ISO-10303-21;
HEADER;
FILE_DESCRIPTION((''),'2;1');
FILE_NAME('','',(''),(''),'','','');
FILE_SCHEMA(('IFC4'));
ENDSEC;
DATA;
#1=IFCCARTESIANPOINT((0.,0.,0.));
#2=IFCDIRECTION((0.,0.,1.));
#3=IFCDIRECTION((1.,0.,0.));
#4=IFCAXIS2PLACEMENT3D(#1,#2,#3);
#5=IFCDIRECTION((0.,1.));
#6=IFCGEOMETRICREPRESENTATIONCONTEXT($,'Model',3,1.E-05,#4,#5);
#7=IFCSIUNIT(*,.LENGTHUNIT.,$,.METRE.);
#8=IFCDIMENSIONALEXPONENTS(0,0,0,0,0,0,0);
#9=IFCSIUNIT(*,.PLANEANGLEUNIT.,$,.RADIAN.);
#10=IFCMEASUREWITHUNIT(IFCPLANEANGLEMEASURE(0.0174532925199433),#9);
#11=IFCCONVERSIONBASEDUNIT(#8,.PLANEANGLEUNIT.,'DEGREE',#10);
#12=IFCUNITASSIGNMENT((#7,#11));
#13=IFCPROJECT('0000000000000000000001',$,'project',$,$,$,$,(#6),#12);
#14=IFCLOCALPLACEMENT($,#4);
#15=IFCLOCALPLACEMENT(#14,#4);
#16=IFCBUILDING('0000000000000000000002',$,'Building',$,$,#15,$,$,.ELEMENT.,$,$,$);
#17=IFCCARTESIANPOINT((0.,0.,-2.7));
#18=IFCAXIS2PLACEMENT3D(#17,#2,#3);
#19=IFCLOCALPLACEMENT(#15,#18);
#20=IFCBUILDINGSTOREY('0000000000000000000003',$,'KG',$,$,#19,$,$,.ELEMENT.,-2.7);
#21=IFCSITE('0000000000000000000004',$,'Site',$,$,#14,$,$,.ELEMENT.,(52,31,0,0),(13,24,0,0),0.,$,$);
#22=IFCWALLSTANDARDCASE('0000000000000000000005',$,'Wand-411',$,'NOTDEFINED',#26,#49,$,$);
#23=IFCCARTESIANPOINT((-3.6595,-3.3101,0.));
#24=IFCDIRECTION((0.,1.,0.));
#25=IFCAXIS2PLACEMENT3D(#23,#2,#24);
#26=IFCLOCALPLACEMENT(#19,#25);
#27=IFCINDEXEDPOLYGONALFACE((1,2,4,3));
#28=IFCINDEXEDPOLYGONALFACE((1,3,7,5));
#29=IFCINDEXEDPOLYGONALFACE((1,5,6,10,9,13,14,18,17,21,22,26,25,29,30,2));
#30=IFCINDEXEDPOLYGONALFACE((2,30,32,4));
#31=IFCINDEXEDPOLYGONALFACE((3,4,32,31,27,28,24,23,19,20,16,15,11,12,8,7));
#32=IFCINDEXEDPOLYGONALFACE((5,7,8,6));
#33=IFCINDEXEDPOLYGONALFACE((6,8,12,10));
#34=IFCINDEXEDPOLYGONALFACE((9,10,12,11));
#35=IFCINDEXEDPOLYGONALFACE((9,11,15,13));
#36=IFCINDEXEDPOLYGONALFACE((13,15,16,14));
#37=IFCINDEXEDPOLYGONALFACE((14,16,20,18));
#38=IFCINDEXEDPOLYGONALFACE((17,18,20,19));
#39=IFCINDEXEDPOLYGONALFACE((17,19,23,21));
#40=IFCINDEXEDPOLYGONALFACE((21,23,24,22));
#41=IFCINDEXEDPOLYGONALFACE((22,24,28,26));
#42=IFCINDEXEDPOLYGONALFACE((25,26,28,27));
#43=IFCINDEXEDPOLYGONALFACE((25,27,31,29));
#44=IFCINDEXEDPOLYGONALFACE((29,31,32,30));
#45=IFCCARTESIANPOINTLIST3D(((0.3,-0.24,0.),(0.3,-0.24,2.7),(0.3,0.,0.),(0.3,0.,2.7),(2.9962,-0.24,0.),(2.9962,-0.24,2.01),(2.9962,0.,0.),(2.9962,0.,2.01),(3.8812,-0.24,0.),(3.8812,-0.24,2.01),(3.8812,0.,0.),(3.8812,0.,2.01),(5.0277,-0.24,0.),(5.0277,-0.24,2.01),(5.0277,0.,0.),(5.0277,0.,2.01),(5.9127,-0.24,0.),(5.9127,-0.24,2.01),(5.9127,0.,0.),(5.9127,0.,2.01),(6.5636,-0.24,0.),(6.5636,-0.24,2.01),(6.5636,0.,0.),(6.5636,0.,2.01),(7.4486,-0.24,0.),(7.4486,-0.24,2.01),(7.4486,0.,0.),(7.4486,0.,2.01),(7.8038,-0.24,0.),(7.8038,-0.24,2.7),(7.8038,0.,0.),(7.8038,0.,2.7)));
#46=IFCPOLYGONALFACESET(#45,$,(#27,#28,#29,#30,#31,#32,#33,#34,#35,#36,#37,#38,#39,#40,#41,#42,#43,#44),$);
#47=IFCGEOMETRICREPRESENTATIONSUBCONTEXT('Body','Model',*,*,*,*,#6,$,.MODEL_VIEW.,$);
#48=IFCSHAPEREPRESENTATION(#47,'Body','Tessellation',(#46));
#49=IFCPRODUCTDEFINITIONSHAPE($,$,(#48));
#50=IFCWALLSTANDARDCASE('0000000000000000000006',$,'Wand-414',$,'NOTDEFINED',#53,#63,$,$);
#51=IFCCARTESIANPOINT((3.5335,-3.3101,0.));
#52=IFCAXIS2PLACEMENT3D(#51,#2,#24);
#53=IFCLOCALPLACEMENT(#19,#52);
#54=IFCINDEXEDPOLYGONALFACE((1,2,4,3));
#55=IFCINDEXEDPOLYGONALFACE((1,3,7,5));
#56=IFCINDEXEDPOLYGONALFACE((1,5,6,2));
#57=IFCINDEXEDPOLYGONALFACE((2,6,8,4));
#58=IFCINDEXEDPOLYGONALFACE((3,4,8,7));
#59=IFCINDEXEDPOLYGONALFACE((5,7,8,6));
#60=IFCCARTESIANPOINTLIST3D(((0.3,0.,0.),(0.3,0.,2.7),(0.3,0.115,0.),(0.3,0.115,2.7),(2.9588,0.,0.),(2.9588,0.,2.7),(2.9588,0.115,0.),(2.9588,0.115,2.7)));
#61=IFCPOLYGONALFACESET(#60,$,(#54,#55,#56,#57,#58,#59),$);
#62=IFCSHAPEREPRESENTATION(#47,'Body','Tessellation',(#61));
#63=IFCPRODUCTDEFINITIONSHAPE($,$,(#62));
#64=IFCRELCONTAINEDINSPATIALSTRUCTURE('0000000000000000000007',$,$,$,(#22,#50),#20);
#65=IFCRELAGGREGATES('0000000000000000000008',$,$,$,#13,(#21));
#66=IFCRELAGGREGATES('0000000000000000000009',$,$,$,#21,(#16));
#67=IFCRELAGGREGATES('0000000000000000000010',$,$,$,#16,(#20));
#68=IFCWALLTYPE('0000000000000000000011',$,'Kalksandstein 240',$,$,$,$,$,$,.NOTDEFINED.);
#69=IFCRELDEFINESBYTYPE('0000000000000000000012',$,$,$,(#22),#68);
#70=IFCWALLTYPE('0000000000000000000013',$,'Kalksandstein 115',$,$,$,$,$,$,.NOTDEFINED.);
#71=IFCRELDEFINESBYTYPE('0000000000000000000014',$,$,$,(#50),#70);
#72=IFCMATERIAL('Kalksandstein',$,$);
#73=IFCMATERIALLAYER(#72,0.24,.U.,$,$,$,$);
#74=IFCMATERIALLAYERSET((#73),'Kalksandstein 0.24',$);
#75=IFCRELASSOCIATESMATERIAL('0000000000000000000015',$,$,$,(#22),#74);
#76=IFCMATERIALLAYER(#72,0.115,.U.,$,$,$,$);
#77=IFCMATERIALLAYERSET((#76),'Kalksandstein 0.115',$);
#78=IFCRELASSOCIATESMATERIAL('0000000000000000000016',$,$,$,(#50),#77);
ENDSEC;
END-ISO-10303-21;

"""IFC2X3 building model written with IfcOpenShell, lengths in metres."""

from ifc_helpers import new_model, entity, si_unit, converted_unit, direction, frame, origin_with_axes, origin_2d_with_axis, place, context, subcontext, project, spatial, polyline, rectangle, outline, extrude, material, layer, layer_set, layer_usage, type_object, element, save


model = new_model("IFC2X3")

# Units and contexts
model_context = context("Model", 3, precision=1e-05, world=origin_with_axes(), true_north=direction((0.0, 1.0)))
body_context = subcontext(model_context, "Body", "Model", "MODEL_VIEW")
ifc_project = project(units=[si_unit("LENGTHUNIT", "METRE"), converted_unit("PLANEANGLEUNIT", "DEGREE", entity("IfcPlaneAngleMeasure", 0.0174532925199433), si_unit("PLANEANGLEUNIT", "RADIAN"), dimensions=[0, 0, 0, 0, 0, 0, 0])], contexts=[model_context])

# Site, building, storey
site_placement = place(None, origin_with_axes())
site = spatial("IfcSite", under=ifc_project, at=site_placement, Name="Site", CompositionType="ELEMENT", RefLatitude=(52, 31, 0, 0), RefLongitude=(13, 24, 0, 0), RefElevation=0.0)
building_placement = place(site_placement, origin_with_axes())
building = spatial("IfcBuilding", under=site, at=building_placement, Name="Building", CompositionType="ELEMENT")
storey_placement = place(building_placement, frame((0.0, 0.0, -2.7), z_axis=(0.0, 0.0, 1.0), x_axis=(1.0, 0.0, 0.0)))
storey = spatial("IfcBuildingStorey", under=building, at=storey_placement, Name="KG", CompositionType="ELEMENT", Elevation=-2.7)

# Shared definitions
ifc_material = material(Name="Kalksandstein")

# Wall, openings
ifc_layer_1 = layer(ifc_material, 0.24, ventilated="UNKNOWN")
ifc_layer_set_1 = layer_set([ifc_layer_1], Name="Kalksandstein 0.24")
ifc_layer_usage_1 = layer_usage(ifc_layer_set_1, "AXIS2", "NEGATIVE", 0.0)
wall_type_1 = type_object("IfcWallType", Name="Kalksandstein 240", PredefinedType="NOTDEFINED")
wall_1_placement = place(storey_placement, frame((-3.6595, -3.3101, 0.0), z_axis=(0.0, 0.0, 1.0), x_axis=(0.0, 1.0, 0.0)))
wall_1 = element("IfcWallStandardCase", 1, at=wall_1_placement, inside=storey, type_object=wall_type_1, material=ifc_layer_usage_1, Name="Wand-411", ObjectType="NOTDEFINED", context=body_context, shape_type="SweptSolid", body=[
    extrude(outline(polyline([(0.3, -0.24), (7.8038, -0.24), (7.8038, 0.0), (0.3, 0.0), (0.3, -0.24)])), origin_with_axes(), (0.0, 0.0, 1.0), 2.7),
])
opening_1_placement = place(wall_1_placement, frame((7.0061, 0.0, 0.0), z_axis=(0.0, 0.0, 1.0), x_axis=(1.0, 0.0, 0.0)))
element("IfcOpeningElement", 2, at=opening_1_placement, cuts=wall_1, context=body_context, shape_type="SweptSolid", body=[
    extrude(rectangle(XDim=0.885, YDim=2.01, at=origin_2d_with_axis()), frame((0.0, -0.24, 1.005), z_axis=(0.0, -1.0, 0.0), x_axis=(-1.0, 0.0, 0.0)), (0.0, 0.0, -1.0), 0.72),
])
opening_2_placement = place(wall_1_placement, frame((3.4387, 0.0, 0.0), z_axis=(0.0, 0.0, 1.0), x_axis=(1.0, 0.0, 0.0)))
element("IfcOpeningElement", 3, at=opening_2_placement, cuts=wall_1, context=body_context, shape_type="SweptSolid", body=[
    extrude(rectangle(XDim=0.885, YDim=2.01, at=origin_2d_with_axis()), frame((0.0, -0.24, 1.005), z_axis=(0.0, 1.0, 0.0), x_axis=(1.0, 0.0, 0.0)), (0.0, 0.0, 1.0), 0.72),
])
opening_3_placement = place(wall_1_placement, frame((5.4702, 0.0, 0.0), z_axis=(0.0, 0.0, 1.0), x_axis=(1.0, 0.0, 0.0)))
element("IfcOpeningElement", 4, at=opening_3_placement, cuts=wall_1, context=body_context, shape_type="SweptSolid", body=[
    extrude(rectangle(XDim=0.885, YDim=2.01, at=origin_2d_with_axis()), frame((0.0, -0.24, 1.005), z_axis=(0.0, 1.0, 0.0), x_axis=(1.0, 0.0, 0.0)), (0.0, 0.0, 1.0), 0.72),
])

# Wall
ifc_layer_2 = layer(ifc_material, 0.115, ventilated="UNKNOWN")
ifc_layer_set_2 = layer_set([ifc_layer_2], Name="Kalksandstein 0.115")
ifc_layer_usage_2 = layer_usage(ifc_layer_set_2, "AXIS2", "POSITIVE", 0.0)
wall_type_2 = type_object("IfcWallType", Name="Kalksandstein 115", PredefinedType="NOTDEFINED")
wall_2_placement = place(storey_placement, frame((3.5335, -3.3101, 0.0), z_axis=(0.0, 0.0, 1.0), x_axis=(0.0, 1.0, 0.0)))
element("IfcWallStandardCase", 5, at=wall_2_placement, inside=storey, type_object=wall_type_2, material=ifc_layer_usage_2, Name="Wand-414", ObjectType="NOTDEFINED", context=body_context, shape_type="SweptSolid", body=[
    extrude(outline(polyline([(0.3, 0.0), (2.9588, 0.0), (2.9588, 0.115), (0.3, 0.115), (0.3, 0.0)])), origin_with_axes(), (0.0, 0.0, 1.0), 2.7),
])

save(model, "model.ifc")
